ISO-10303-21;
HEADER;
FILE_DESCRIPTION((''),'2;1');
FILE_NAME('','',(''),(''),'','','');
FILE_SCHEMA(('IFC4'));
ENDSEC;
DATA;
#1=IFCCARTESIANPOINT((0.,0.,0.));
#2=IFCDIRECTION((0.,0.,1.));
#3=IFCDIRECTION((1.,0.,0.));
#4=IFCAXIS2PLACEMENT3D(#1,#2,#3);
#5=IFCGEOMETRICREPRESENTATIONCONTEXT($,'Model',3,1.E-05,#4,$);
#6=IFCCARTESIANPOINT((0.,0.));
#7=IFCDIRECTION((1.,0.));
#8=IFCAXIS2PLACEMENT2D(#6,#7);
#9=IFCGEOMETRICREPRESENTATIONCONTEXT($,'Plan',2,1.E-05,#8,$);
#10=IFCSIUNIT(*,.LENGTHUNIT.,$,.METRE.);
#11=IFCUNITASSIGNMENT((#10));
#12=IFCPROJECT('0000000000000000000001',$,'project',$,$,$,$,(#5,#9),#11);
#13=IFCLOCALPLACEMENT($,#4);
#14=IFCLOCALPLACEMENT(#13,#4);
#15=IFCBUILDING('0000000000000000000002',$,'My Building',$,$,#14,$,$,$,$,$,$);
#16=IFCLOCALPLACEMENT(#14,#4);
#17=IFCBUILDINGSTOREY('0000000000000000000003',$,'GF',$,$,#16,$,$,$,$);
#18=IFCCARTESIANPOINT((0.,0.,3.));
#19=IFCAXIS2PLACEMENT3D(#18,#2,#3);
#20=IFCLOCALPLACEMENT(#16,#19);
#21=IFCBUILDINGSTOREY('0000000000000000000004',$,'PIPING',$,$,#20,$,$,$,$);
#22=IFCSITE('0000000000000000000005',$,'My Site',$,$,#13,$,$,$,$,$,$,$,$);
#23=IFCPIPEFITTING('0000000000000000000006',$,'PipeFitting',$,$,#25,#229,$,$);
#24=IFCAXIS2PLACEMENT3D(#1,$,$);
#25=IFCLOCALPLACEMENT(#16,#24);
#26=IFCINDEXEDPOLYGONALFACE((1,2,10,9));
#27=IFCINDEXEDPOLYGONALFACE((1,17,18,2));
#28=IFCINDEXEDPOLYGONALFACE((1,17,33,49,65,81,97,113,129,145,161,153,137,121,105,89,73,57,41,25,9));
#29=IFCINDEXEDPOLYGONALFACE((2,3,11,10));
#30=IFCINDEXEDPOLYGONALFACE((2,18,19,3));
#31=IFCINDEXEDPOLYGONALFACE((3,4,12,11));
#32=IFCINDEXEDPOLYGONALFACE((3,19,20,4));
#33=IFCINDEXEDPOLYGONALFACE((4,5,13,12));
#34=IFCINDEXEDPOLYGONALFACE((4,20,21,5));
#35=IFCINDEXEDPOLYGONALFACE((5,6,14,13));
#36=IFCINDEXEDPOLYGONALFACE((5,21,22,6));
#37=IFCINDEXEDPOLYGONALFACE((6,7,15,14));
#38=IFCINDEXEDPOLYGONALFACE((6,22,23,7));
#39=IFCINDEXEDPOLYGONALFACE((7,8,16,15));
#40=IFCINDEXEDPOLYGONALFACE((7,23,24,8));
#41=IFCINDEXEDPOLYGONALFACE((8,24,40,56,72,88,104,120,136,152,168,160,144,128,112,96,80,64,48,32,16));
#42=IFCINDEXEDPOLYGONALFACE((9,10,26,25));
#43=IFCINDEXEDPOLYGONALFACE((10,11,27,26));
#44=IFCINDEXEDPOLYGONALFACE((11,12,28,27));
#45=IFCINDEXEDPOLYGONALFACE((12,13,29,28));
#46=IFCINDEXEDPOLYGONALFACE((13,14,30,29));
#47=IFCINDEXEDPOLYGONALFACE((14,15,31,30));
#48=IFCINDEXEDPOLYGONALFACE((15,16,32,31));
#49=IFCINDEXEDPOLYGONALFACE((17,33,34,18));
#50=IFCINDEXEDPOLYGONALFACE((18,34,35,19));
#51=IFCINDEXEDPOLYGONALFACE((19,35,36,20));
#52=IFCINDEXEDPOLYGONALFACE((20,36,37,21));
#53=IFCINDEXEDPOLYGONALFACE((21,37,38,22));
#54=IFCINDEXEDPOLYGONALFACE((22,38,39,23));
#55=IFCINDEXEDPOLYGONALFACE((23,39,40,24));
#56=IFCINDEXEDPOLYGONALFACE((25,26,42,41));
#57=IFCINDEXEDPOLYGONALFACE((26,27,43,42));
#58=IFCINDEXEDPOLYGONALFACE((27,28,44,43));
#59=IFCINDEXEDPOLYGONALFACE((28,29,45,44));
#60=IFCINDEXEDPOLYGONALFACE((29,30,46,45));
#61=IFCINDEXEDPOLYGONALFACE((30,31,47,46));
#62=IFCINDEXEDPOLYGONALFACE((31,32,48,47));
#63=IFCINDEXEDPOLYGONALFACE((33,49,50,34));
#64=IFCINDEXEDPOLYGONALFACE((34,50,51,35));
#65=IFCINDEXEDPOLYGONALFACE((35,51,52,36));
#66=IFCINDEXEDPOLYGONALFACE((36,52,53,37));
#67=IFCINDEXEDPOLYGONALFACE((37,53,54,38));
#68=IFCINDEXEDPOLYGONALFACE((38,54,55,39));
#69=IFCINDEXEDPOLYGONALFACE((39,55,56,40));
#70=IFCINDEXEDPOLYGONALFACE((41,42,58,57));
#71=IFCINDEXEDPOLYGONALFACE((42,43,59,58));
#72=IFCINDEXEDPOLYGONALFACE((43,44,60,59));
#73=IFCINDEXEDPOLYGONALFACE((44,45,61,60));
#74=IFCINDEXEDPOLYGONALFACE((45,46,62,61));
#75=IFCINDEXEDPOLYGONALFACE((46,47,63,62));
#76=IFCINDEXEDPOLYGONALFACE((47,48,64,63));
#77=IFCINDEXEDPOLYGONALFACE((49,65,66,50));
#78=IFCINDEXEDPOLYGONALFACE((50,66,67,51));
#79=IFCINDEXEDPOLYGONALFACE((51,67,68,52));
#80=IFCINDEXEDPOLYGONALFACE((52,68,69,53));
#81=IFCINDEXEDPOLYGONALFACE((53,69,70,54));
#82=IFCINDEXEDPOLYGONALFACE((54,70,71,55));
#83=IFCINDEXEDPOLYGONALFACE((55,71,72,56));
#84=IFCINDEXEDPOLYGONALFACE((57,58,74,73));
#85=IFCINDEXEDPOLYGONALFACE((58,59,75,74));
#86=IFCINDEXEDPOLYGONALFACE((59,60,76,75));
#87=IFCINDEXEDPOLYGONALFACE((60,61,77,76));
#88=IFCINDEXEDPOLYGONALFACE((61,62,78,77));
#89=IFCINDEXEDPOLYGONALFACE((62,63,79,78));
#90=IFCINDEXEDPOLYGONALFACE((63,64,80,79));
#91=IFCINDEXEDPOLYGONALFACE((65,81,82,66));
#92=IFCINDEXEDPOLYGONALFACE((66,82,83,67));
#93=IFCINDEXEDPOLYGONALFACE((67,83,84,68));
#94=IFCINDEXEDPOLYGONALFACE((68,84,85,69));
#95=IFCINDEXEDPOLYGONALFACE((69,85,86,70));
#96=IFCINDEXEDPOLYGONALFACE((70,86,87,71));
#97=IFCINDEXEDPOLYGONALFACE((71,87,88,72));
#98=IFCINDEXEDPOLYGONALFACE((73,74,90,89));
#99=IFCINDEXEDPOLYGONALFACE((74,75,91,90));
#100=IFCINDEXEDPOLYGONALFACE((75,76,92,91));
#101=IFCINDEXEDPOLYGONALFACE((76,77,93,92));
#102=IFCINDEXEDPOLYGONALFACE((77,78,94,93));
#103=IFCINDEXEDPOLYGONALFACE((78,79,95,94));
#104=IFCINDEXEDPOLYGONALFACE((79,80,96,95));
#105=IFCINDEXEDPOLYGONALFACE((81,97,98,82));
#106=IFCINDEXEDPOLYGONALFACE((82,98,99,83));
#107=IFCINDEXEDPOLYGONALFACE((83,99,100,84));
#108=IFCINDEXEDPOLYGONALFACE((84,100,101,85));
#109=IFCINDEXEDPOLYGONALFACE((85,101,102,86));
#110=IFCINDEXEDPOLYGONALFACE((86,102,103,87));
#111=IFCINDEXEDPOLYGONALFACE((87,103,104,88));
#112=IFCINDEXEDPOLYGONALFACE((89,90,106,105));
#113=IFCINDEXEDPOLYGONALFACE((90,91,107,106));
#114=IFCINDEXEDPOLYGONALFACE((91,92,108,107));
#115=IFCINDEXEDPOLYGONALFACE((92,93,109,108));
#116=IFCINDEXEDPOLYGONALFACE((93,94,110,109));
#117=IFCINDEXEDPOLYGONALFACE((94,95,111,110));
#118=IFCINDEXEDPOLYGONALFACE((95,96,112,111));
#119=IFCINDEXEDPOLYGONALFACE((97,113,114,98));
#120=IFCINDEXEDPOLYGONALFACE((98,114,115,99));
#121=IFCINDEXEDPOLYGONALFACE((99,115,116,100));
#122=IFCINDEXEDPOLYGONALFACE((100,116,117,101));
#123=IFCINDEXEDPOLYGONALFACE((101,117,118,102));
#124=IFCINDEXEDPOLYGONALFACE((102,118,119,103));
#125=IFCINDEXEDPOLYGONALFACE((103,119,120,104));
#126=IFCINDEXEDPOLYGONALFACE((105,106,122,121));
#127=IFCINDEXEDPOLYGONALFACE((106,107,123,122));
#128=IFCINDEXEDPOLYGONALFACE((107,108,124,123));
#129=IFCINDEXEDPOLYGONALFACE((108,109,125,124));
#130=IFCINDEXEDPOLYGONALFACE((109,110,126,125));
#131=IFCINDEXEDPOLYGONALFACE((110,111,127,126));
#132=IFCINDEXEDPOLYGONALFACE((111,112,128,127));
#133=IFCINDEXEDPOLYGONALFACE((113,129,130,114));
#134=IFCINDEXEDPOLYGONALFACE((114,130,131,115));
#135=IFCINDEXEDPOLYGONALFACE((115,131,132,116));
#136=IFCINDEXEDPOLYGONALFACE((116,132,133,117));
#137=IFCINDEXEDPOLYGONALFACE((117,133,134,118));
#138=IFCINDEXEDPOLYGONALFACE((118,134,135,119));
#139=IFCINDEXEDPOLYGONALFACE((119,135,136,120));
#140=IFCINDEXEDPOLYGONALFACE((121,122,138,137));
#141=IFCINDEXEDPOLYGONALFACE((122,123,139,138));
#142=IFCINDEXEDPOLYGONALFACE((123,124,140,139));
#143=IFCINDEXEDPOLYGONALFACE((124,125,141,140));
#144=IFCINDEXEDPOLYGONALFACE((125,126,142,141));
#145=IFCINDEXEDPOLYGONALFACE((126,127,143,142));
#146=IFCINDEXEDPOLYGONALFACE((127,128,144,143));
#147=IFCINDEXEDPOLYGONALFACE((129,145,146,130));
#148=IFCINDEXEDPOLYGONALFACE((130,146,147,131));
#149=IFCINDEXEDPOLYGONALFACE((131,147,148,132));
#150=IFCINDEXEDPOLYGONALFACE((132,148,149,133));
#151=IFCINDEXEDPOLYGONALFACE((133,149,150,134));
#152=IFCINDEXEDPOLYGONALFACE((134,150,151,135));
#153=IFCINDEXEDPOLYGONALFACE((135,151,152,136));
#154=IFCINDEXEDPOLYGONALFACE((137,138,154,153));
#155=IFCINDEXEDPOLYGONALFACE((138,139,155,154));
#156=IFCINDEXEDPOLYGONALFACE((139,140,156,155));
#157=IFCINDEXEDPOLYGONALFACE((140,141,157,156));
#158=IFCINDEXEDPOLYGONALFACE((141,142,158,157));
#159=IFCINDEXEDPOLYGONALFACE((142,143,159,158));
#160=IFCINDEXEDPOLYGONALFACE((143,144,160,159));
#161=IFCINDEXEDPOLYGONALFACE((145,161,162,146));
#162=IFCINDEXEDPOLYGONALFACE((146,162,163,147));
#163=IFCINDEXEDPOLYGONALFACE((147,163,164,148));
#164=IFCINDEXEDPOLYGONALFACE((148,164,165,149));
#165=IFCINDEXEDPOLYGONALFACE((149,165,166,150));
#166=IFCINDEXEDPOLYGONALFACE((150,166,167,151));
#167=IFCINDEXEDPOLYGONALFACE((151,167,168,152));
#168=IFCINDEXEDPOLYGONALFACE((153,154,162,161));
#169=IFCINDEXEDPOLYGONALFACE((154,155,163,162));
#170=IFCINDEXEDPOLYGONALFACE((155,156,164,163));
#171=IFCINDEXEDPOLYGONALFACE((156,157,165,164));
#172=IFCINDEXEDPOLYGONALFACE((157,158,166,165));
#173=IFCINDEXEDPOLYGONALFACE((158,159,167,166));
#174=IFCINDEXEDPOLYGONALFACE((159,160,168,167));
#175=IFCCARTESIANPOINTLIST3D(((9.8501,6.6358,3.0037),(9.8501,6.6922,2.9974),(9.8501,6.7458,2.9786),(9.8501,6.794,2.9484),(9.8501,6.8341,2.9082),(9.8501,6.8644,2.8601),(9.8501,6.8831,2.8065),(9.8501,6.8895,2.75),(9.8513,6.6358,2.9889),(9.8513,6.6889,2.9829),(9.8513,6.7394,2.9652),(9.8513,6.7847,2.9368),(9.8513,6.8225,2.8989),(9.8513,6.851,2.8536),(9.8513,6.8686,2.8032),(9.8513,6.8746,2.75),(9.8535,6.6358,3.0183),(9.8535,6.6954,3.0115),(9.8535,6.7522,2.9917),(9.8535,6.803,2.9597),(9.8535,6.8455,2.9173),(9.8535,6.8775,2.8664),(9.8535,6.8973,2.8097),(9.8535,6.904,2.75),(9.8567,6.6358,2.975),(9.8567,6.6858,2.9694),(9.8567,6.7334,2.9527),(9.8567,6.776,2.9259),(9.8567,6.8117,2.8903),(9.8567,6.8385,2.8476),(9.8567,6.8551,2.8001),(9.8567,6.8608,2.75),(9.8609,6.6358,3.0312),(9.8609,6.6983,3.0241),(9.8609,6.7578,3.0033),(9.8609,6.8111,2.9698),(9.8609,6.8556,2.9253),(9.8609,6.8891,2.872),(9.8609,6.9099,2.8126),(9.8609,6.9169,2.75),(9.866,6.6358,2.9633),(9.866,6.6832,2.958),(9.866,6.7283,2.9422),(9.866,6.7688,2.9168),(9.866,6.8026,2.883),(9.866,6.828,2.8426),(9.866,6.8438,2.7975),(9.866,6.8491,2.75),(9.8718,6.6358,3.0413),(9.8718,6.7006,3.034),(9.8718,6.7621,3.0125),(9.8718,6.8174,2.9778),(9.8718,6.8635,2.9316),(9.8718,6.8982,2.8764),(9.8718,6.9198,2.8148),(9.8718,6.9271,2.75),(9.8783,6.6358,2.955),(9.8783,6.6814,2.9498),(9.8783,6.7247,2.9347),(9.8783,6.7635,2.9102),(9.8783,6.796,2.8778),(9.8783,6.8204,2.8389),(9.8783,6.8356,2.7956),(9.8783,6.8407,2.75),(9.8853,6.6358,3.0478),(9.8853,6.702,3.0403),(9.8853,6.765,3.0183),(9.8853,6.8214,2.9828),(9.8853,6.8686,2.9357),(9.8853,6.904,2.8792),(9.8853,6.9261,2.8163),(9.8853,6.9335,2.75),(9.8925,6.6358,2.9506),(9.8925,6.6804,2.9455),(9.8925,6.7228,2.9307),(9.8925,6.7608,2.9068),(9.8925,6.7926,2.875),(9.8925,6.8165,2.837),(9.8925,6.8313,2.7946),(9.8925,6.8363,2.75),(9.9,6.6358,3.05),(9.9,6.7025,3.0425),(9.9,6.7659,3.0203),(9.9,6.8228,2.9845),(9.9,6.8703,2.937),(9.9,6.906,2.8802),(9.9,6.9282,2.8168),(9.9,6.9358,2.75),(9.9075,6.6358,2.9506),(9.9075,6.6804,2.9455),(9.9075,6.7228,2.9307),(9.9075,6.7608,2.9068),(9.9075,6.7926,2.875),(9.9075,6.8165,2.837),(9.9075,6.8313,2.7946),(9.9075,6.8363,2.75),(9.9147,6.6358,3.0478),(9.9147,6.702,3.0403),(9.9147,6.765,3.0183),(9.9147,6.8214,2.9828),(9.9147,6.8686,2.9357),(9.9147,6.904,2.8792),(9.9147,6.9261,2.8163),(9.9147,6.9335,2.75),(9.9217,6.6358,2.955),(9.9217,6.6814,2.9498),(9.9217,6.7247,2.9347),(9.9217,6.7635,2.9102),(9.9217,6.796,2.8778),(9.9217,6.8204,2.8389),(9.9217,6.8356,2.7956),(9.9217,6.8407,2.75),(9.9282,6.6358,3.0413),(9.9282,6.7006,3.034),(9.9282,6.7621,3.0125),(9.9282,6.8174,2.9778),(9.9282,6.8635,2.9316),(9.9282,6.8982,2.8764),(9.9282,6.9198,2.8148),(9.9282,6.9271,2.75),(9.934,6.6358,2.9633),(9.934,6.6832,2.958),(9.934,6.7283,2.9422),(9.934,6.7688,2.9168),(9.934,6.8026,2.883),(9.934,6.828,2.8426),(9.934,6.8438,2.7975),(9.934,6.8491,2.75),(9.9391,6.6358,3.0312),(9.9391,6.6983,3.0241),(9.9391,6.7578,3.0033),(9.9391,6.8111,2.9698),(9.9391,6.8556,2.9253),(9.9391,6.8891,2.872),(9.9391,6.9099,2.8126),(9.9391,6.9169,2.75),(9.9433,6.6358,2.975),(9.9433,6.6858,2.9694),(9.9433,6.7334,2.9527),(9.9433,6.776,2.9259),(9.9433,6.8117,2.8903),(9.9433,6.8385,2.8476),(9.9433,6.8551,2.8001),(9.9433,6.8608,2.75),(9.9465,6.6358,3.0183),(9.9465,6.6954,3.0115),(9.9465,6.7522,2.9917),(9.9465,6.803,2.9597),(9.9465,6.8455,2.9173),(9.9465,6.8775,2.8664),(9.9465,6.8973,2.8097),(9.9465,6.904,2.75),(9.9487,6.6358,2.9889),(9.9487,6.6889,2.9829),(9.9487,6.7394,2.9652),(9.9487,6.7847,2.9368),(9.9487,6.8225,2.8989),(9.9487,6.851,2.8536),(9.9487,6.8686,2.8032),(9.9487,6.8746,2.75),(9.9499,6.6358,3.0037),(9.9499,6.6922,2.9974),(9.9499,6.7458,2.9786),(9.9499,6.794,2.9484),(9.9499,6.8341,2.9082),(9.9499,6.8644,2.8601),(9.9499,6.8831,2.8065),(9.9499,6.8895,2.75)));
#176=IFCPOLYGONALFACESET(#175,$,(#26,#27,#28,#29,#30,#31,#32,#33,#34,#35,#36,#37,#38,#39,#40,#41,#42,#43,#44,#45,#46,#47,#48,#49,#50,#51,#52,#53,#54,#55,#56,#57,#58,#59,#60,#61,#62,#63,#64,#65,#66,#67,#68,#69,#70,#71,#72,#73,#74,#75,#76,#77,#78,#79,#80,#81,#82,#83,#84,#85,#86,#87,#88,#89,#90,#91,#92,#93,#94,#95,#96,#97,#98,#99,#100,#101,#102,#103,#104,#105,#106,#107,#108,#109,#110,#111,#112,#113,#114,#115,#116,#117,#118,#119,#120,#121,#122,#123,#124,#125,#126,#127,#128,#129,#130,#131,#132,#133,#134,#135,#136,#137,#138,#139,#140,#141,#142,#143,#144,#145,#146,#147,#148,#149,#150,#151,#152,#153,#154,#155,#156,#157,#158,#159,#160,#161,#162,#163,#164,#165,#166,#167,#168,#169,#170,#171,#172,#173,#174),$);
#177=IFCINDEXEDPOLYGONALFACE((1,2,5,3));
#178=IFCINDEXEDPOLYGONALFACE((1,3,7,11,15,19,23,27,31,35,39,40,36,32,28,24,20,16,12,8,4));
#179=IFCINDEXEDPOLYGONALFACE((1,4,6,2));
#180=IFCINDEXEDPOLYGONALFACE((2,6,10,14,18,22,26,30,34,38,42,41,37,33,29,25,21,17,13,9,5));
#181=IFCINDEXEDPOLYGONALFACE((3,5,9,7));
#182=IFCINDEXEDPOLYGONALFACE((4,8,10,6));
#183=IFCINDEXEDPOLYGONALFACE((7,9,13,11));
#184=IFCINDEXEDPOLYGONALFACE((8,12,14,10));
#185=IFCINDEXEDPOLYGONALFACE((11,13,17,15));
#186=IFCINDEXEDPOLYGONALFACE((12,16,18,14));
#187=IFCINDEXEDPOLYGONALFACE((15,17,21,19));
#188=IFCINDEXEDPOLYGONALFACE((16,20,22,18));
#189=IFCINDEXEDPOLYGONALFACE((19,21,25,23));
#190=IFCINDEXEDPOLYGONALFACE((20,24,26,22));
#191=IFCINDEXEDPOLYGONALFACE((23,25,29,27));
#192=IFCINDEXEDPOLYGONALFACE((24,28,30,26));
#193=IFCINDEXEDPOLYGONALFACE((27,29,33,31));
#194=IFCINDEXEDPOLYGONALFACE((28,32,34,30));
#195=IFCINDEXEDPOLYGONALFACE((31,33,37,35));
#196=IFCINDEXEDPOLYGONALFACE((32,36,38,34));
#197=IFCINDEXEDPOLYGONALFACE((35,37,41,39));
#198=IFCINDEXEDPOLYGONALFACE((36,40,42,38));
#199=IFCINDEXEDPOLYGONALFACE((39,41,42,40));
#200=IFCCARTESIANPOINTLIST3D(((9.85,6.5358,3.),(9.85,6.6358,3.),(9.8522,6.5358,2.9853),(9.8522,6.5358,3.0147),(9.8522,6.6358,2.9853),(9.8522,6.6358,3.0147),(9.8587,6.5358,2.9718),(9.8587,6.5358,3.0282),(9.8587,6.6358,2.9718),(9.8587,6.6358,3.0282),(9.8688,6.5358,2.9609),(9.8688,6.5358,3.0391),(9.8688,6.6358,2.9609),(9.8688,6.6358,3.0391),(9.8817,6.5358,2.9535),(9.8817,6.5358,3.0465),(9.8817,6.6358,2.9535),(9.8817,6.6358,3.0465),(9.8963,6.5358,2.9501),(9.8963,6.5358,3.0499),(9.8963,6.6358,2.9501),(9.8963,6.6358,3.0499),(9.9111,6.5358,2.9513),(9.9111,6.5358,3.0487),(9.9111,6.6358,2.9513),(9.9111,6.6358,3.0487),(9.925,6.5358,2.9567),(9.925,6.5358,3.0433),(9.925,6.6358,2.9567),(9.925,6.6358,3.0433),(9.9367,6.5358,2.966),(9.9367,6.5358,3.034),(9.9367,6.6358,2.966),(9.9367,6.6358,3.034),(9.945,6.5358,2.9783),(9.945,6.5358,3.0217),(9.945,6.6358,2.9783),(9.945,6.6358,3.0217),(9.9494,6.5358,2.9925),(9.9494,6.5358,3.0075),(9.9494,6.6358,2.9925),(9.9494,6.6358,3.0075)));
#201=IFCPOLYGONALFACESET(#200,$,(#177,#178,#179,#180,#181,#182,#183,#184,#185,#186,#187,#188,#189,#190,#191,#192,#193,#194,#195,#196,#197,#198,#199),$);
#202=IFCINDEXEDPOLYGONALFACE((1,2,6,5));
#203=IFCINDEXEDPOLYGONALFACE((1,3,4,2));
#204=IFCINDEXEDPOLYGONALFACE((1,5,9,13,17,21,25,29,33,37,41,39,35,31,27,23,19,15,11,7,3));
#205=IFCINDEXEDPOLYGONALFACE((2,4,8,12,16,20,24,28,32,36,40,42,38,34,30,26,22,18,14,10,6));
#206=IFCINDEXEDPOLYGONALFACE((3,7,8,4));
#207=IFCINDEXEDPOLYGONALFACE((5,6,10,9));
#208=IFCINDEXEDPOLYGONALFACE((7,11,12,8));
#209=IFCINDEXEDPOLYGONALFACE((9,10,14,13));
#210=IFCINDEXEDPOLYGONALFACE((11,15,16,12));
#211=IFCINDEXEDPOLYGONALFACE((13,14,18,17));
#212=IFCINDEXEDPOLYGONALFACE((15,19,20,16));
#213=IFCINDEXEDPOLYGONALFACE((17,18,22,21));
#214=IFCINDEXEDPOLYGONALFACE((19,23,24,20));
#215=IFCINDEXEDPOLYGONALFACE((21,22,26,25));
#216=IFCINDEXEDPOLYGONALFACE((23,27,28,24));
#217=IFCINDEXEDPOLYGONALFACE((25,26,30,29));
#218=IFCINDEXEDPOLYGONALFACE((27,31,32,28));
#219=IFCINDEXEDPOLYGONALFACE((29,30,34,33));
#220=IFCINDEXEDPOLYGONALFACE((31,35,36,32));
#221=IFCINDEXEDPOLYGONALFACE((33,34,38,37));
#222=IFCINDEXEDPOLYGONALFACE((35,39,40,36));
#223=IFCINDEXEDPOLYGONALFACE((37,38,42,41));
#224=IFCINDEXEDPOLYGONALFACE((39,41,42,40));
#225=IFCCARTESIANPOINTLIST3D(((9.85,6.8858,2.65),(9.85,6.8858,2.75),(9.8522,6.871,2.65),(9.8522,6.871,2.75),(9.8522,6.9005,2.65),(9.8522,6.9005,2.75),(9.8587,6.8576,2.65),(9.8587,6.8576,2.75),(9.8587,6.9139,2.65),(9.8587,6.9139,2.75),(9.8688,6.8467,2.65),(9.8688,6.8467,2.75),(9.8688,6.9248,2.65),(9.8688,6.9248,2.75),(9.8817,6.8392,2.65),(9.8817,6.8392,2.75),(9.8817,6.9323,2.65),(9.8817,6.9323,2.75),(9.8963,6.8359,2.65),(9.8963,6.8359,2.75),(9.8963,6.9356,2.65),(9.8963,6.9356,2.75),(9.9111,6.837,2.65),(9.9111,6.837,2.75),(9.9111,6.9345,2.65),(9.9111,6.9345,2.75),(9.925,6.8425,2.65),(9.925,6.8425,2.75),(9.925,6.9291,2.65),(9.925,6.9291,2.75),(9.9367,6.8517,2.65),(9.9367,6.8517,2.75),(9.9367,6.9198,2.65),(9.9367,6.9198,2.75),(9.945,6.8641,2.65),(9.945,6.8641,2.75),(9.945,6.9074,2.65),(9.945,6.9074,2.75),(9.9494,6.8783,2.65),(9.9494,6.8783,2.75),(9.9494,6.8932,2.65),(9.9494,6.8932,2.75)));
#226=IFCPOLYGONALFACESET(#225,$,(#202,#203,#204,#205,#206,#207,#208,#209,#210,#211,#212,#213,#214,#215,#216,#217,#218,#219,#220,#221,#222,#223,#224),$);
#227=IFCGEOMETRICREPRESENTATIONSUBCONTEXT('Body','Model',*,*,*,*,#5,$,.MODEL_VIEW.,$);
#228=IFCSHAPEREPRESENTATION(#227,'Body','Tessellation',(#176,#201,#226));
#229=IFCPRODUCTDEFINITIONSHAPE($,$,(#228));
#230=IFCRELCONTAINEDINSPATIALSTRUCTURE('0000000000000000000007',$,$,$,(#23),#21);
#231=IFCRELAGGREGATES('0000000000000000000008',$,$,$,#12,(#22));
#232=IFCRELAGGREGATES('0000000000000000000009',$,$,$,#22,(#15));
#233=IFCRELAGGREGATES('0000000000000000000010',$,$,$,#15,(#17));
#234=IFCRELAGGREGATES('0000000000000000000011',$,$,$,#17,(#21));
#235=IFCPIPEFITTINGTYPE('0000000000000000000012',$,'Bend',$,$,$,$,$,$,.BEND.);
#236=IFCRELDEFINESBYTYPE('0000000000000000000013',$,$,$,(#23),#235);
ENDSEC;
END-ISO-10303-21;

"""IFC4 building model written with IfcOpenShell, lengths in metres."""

from ifc_helpers import new_model, entity, si_unit, frame, origin_with_axes, origin_2d_with_axis, place, context, subcontext, project, spatial, circle, extrude, source, transform, mapped, type_object, type_shapes, element, save


model = new_model("IFC4")

# Units and contexts
model_context = context("Model", 3, precision=1e-05, world=origin_with_axes())
plan_context = context("Plan", 2, precision=1e-05, world=origin_2d_with_axis())
body_context = subcontext(model_context, "Body", "Model", "MODEL_VIEW")
ifc_project = project(units=[si_unit("LENGTHUNIT", "METRE")], contexts=[model_context, plan_context])

# Site, building, storeys
site_placement = place(None, origin_with_axes())
site = spatial("IfcSite", under=ifc_project, at=site_placement, Name="My Site")
building_placement = place(site_placement, origin_with_axes())
building = spatial("IfcBuilding", under=site, at=building_placement, Name="My Building")
storey_1_placement = place(building_placement, origin_with_axes())
storey_1 = spatial("IfcBuildingStorey", under=building, at=storey_1_placement, Name="GF")
storey_2_placement = place(storey_1_placement, frame((0.0, 0.0, 3.0), z_axis=(0.0, 0.0, 1.0), x_axis=(1.0, 0.0, 0.0)))
storey_2 = spatial("IfcBuildingStorey", under=storey_1, at=storey_2_placement, Name="PIPING")

# Pipe fitting
pipe_fitting_type = type_object("IfcPipeFittingType", Name="Bend", PredefinedType="BEND")
shared_shape = source(origin_with_axes(), body_context, "Body", "SolidModel", [
    entity("IfcSweptDiskSolid", entity("IfcIndexedPolyCurve", entity("IfcCartesianPointList3D", [[0.0, 0.0, -0.1], [0.0, 0.0732, -0.2768], [0.0, 0.25, -0.35]]), [entity("IfcArcIndex", [1, 2, 3])]), 0.05),
    extrude(circle(Radius=0.05), origin_with_axes(), (0.0, 0.0, -1.0), 0.1),
    extrude(circle(Radius=0.05), frame((0.0, 0.25, -0.35), z_axis=(0.0, 1.0, 0.0), x_axis=(1.0, 0.0, 0.0)), (0.0, 0.0, 1.0), 0.1),
])
type_shapes(pipe_fitting_type, [shared_shape])
for number, where, z_axis, x_axis, name in (
    (1, (9.9, 6.5358, 0.0), (0.0, -1.0, 0.0), (-1.0, 0.0, 0.0), "PipeFitting"),
):
    element("IfcPipeFitting", number, at=place(storey_2_placement, frame(where, z_axis=z_axis, x_axis=x_axis)), inside=storey_2, type_object=pipe_fitting_type, Name=name, context=body_context, shape_type="MappedRepresentation", body=[
        mapped(shared_shape, transform((0.0, 0.0, 0.0), x_axis=(1.0, 0.0, 0.0), y_axis=(0.0, 1.0, 0.0), z_axis=(0.0, 0.0, 1.0), scale=1.0)),
    ])

save(model, "model.ifc")
